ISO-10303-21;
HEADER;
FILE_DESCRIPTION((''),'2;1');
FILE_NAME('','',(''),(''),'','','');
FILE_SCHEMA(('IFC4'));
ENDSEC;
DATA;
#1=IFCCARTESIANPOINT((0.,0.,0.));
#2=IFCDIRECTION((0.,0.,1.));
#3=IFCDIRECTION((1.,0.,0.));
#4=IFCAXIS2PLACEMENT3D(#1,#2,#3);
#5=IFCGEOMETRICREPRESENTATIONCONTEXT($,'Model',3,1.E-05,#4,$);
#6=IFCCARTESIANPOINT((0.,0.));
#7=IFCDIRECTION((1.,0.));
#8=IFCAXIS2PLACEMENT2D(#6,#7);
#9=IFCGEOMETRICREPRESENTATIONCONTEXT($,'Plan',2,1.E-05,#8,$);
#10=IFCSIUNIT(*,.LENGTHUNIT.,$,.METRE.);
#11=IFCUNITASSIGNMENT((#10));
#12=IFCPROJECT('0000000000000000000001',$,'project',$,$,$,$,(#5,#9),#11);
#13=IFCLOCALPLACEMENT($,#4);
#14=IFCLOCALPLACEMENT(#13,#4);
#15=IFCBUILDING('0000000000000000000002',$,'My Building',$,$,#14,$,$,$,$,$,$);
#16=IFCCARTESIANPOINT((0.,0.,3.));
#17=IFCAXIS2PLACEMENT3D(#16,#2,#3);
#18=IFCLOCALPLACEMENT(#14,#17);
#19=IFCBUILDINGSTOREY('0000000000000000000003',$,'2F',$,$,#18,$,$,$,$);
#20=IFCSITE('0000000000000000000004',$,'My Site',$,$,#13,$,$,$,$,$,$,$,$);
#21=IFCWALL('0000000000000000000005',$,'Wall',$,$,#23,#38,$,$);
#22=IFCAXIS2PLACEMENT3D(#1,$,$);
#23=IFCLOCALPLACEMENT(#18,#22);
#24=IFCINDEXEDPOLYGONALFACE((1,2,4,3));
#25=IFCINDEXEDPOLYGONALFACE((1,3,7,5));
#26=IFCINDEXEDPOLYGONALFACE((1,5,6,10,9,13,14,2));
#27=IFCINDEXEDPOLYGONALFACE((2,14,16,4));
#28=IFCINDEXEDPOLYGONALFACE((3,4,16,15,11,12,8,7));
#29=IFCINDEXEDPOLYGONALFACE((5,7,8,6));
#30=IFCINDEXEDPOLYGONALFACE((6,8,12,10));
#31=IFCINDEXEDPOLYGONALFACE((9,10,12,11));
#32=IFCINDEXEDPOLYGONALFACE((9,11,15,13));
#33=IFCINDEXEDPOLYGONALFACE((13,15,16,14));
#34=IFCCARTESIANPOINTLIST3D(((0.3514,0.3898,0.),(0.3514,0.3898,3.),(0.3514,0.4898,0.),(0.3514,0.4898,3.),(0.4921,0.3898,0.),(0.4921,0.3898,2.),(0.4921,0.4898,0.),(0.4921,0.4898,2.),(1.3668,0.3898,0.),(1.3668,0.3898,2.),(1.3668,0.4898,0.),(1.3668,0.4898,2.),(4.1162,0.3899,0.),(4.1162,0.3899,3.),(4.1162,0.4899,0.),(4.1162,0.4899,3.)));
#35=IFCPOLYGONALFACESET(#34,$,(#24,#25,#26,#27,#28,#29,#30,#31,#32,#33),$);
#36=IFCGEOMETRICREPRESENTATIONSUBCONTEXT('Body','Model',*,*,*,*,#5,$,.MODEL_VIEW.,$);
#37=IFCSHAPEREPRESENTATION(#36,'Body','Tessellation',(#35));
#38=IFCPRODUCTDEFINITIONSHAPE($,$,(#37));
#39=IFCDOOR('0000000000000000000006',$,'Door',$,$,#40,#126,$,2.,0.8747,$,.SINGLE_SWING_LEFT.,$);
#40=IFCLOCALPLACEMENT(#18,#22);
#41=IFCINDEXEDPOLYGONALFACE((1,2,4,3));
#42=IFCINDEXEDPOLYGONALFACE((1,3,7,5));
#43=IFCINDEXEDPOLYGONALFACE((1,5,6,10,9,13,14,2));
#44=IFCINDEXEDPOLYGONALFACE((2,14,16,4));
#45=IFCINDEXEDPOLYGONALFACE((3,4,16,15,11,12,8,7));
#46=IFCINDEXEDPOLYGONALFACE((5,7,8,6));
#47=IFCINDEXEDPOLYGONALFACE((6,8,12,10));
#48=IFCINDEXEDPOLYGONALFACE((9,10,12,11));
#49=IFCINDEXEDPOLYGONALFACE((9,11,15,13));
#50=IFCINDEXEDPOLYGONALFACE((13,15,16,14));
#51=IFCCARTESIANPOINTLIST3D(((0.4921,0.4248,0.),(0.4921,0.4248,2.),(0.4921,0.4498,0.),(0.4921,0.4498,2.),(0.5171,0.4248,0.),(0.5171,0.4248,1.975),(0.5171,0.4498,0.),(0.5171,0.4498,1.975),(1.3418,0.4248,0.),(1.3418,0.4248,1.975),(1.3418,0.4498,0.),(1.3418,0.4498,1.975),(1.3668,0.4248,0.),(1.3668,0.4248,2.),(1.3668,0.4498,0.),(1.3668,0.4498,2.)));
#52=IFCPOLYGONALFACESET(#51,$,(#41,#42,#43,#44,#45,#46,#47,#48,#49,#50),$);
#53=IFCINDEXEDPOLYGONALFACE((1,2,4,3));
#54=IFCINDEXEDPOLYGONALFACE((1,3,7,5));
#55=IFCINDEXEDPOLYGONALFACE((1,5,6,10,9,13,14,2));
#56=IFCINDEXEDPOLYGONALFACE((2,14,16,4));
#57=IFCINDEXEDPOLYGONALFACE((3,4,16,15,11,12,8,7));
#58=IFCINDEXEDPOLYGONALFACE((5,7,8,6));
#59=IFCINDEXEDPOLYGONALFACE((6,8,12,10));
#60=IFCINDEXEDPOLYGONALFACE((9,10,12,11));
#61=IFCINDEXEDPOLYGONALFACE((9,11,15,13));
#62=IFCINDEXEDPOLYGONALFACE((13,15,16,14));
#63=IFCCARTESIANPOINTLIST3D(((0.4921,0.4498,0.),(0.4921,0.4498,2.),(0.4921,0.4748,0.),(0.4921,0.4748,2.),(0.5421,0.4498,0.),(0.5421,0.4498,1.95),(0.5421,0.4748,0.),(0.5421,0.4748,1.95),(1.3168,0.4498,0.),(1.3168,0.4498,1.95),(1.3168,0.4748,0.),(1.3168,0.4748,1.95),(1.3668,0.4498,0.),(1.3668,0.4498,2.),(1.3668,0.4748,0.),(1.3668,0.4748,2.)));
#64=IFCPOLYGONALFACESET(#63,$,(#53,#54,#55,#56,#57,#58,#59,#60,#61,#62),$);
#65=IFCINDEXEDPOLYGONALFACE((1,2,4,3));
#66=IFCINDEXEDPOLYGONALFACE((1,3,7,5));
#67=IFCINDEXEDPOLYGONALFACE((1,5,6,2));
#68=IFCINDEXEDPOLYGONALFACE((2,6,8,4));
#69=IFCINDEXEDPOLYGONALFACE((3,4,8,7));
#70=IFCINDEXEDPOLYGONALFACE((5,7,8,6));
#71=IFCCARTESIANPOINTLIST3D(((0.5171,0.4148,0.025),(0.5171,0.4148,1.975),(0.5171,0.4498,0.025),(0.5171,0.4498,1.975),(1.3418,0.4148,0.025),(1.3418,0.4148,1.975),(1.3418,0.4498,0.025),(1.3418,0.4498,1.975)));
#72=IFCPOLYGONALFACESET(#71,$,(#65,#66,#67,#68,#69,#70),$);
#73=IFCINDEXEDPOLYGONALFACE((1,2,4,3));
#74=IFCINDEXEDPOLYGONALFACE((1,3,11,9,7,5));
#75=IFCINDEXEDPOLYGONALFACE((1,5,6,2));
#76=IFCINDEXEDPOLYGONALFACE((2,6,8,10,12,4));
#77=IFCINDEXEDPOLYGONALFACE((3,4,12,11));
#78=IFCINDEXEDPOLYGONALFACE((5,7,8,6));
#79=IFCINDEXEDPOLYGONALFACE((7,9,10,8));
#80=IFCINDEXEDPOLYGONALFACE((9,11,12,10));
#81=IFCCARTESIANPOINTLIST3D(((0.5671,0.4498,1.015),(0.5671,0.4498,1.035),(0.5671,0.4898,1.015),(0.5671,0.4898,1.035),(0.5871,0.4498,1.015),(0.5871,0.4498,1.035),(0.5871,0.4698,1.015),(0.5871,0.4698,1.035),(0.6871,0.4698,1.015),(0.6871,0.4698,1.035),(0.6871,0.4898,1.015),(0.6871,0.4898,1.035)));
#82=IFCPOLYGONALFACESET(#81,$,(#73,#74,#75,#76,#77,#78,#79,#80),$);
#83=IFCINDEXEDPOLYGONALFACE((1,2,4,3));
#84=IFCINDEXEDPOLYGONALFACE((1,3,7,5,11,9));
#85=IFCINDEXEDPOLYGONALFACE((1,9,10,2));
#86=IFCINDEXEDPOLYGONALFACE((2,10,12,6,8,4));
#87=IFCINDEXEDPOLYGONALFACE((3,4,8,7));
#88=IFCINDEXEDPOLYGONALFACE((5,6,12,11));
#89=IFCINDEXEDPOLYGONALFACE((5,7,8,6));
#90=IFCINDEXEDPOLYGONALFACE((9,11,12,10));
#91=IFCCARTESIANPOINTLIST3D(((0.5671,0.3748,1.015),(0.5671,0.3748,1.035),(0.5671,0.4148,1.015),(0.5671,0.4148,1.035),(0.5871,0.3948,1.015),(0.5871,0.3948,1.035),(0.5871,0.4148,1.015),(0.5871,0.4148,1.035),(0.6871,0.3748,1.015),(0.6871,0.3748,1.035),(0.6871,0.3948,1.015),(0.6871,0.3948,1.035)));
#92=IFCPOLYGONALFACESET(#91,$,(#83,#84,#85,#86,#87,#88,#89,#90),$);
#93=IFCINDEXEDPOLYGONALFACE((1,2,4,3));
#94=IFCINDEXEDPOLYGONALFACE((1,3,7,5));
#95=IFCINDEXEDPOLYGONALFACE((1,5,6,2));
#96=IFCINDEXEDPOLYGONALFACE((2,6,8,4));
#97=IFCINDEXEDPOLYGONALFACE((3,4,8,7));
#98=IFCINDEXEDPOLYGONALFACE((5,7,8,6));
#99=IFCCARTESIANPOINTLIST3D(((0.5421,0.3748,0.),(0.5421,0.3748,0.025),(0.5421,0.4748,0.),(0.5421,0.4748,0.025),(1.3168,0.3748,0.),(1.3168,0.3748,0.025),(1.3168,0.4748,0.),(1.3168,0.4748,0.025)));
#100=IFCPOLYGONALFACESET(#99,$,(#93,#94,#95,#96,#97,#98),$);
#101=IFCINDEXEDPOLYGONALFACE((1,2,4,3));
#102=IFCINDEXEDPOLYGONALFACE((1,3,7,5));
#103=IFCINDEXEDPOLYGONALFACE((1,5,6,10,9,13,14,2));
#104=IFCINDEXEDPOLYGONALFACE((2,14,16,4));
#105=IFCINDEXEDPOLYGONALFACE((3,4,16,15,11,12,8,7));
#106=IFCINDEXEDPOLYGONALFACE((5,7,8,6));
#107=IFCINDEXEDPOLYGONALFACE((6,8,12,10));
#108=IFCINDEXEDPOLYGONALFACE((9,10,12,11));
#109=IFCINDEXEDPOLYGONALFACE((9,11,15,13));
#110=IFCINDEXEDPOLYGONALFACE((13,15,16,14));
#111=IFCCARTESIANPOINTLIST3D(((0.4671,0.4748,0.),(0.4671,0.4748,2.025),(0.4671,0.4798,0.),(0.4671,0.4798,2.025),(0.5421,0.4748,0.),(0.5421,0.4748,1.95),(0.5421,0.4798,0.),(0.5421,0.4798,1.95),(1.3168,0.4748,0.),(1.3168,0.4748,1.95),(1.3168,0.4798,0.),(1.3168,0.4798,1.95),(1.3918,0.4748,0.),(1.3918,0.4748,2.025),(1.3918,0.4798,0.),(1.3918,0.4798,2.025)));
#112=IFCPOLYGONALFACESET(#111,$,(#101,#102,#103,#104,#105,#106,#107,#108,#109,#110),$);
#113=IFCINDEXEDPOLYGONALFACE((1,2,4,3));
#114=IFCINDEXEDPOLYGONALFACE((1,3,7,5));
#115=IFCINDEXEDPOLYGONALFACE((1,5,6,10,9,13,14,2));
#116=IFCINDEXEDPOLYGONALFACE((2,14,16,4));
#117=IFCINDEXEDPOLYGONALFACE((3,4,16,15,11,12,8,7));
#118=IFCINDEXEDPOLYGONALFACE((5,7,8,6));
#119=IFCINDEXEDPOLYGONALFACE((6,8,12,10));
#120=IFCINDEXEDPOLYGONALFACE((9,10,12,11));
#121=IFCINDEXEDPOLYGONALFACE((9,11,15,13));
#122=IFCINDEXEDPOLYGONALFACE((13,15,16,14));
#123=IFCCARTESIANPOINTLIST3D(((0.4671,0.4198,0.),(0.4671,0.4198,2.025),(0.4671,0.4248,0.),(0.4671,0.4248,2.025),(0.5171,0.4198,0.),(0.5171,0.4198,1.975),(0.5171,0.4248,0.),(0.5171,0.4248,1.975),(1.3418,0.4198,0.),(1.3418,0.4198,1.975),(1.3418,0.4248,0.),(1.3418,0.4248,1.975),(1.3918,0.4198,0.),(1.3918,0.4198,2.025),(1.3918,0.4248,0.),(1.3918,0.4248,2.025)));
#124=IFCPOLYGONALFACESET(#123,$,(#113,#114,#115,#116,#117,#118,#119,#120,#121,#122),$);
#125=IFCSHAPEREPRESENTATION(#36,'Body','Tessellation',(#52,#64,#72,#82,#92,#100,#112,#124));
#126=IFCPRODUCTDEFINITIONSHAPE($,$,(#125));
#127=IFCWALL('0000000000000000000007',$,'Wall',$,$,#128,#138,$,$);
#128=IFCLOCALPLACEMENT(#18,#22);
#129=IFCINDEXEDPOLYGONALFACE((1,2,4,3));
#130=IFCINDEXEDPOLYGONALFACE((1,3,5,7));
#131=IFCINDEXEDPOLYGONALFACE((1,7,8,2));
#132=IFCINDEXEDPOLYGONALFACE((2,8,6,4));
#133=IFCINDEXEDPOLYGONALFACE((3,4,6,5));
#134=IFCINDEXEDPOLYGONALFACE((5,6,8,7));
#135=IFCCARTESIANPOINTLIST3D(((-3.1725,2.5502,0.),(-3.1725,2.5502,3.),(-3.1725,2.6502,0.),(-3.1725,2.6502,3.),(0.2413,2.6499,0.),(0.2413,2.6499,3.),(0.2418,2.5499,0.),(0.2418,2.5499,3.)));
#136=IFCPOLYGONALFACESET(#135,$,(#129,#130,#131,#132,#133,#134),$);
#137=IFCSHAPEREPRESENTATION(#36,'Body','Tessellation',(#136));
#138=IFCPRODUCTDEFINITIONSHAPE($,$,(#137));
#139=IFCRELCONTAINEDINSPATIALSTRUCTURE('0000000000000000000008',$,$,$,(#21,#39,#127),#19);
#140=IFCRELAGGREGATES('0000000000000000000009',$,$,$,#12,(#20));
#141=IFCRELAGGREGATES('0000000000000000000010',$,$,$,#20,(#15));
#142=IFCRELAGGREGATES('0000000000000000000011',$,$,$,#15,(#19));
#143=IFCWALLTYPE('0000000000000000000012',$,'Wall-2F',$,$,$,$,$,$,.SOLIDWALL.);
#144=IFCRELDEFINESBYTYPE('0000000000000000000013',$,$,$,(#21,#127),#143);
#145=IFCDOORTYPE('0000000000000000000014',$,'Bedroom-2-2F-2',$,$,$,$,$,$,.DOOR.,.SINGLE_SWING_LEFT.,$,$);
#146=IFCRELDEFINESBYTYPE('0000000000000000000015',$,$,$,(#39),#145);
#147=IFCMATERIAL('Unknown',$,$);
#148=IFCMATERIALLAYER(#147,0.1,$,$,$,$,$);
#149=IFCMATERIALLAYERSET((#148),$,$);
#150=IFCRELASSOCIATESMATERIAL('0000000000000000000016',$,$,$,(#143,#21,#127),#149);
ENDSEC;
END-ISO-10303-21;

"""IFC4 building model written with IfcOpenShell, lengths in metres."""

from ifc_helpers import new_model, entity, si_unit, frame, origin_with_axes, origin_2d_with_axis, place, context, subcontext, project, spatial, line, indexed_curve, outline, extrude, shape, source, transform, mapped, material, layer, layer_set, layer_usage, type_object, type_shapes, element, fill, save


model = new_model("IFC4")

# Units and contexts
model_context = context("Model", 3, precision=1e-05, world=origin_with_axes())
plan_context = context("Plan", 2, precision=1e-05, world=origin_2d_with_axis())
body_context_1 = subcontext(model_context, "Body", "Model", "MODEL_VIEW")
body_context_2 = subcontext(plan_context, "Body", "Plan", "PLAN_VIEW")
ifc_project = project(units=[si_unit("LENGTHUNIT", "METRE")], contexts=[model_context, plan_context])

# Site, building, storey
site_placement = place(None, origin_with_axes())
site = spatial("IfcSite", under=ifc_project, at=site_placement, Name="My Site")
building_placement = place(site_placement, origin_with_axes())
building = spatial("IfcBuilding", under=site, at=building_placement, Name="My Building")
storey_placement = place(building_placement, frame((0.0, 0.0, 3.0), z_axis=(0.0, 0.0, 1.0), x_axis=(1.0, 0.0, 0.0)))
storey = spatial("IfcBuildingStorey", under=building, at=storey_placement, Name="2F")

# Shared definitions
ifc_material = material(Name="Unknown")

# Shared definitions
ifc_layer_1 = layer(ifc_material, 0.1)
ifc_layer_set_1 = layer_set([ifc_layer_1])
wall_type = type_object("IfcWallType", Name="Wall-2F", PredefinedType="SOLIDWALL", material=ifc_layer_set_1)

# Wall, opening, door
ifc_layer_usage_1 = layer_usage(ifc_layer_set_1, "AXIS2", "POSITIVE", 0.0)
wall_1_placement = place(storey_placement, frame((0.3514, 0.3898, 0.0), z_axis=(0.0, 0.0, 1.0), x_axis=(1.0, 0.000024, 0.0)))
wall_1 = element("IfcWall", 1, at=wall_1_placement, inside=storey, type_object=wall_type, material=ifc_layer_usage_1, Name="Wall", context=body_context_1, shape_type="SweptSolid", body=[
    extrude(outline(indexed_curve([(0.0, 0.0), (0.0, 0.1), (3.7648, 0.1), (3.7648, 0.0)], segments=[line(1, 2, 3, 4, 1)])), origin_with_axes(), (0.0, 0.0, 1.0), 3.0),
])
shared_shape_1 = source(origin_with_axes(), body_context_1, "Body", "SweptSolid", [
    extrude(outline(indexed_curve([(0.0, 0.0), (0.8747, 0.0), (0.8747, 2.0), (0.0, 2.0)], segments=[line(1, 2, 3, 4, 1)])), frame((0.0, -0.6, 0.0), z_axis=(0.0, -1.0, 0.0), x_axis=(1.0, 0.0, 0.0)), (0.0, 0.0, -1.0), 1.2),
])
opening_1_placement = place(wall_1_placement, frame((0.1407, 0.0, 0.0), z_axis=(0.0, 0.0, 1.0), x_axis=(1.0, 0.0, 0.0)))
opening_1 = element("IfcOpeningElement", 2, at=opening_1_placement, cuts=wall_1, PredefinedType="OPENING", context=body_context_1, shape_type="MappedRepresentation", body=[
    mapped(shared_shape_1, transform((0.0, 0.0, 0.0), x_axis=(1.0, 0.0, 0.0), y_axis=(0.0, 1.0, 0.0), z_axis=(0.0, 0.0, 1.0), scale=1.0)),
])
door_type_1 = type_object("IfcDoorType", Name="Bedroom-2-2F-2", OperationType="SINGLE_SWING_LEFT", PredefinedType="DOOR")
shared_shape_2 = source(origin_with_axes(), body_context_1, "Body", "SweptSolid", [
    extrude(outline(indexed_curve([(0.0, 0.0), (0.0, 2.0), (0.8747, 2.0), (0.8747, 0.0), (0.8497, 0.0), (0.8497, 1.975), (0.025, 1.975), (0.025, 0.0)], segments=[line(1, 2, 3, 4, 5, 6, 7, 8, 1)])), frame((0.0, 0.025, 0.0), z_axis=(0.0, -1.0, 0.0), x_axis=(1.0, 0.0, 0.0)), (0.0, 0.0, -1.0), 0.025),
    extrude(outline(indexed_curve([(0.0, 0.0), (0.0, 2.0), (0.8747, 2.0), (0.8747, 0.0), (0.8247, 0.0), (0.8247, 1.95), (0.05, 1.95), (0.05, 0.0)], segments=[line(1, 2, 3, 4, 5, 6, 7, 8, 1)])), frame((0.0, 0.0, 0.0), z_axis=(0.0, -1.0, 0.0), x_axis=(1.0, 0.0, 0.0)), (0.0, 0.0, -1.0), 0.025),
    extrude(outline(indexed_curve([(0.0, 0.0), (0.8247, 0.0), (0.8247, 0.035), (0.0, 0.035)], segments=[line(1, 2, 3, 4, 1)])), frame((0.025, 0.025, 0.025), z_axis=(0.0, 0.0, 1.0), x_axis=(1.0, 0.0, 0.0)), (0.0, 0.0, 1.0), 1.95),
    extrude(outline(indexed_curve([(0.0, 0.0), (0.0, -0.04), (-0.12, -0.04), (-0.12, -0.02), (-0.02, -0.02), (-0.02, 0.0)], segments=[line(1, 2, 3, 4, 5, 6, 1)])), frame((0.7997, 0.025, 1.015), z_axis=(0.0, 0.0, 1.0), x_axis=(1.0, 0.0, 0.0)), (0.0, 0.0, 1.0), 0.02),
    extrude(outline(indexed_curve([(0.0, 0.0), (0.0, 0.04), (-0.12, 0.04), (-0.12, 0.02), (-0.02, 0.02), (-0.02, 0.0)], segments=[line(1, 2, 3, 4, 5, 6, 1)])), frame((0.7997, 0.06, 1.015), z_axis=(0.0, 0.0, 1.0), x_axis=(1.0, 0.0, 0.0)), (0.0, 0.0, 1.0), 0.02),
    extrude(outline(indexed_curve([(0.0, 0.0), (0.7747, 0.0), (0.7747, 0.1), (0.0, 0.1)], segments=[line(1, 2, 3, 4, 1)])), frame((0.05, 0.0, 0.0), z_axis=(0.0, 0.0, 1.0), x_axis=(1.0, 0.0, 0.0)), (0.0, 0.0, 1.0), 0.025),
    extrude(outline(indexed_curve([(0.0, 0.0), (0.0, 2.025), (0.9247, 2.025), (0.9247, 0.0), (0.8497, 0.0), (0.8497, 1.95), (0.075, 1.95), (0.075, 0.0)], segments=[line(1, 2, 3, 4, 5, 6, 7, 8, 1)])), frame((-0.025, -0.005, 0.0), z_axis=(0.0, -1.0, 0.0), x_axis=(1.0, 0.0, 0.0)), (0.0, 0.0, -1.0), 0.005),
    extrude(outline(indexed_curve([(0.0, 0.0), (0.0, 2.025), (0.9247, 2.025), (0.9247, 0.0), (0.8747, 0.0), (0.8747, 1.975), (0.05, 1.975), (0.05, 0.0)], segments=[line(1, 2, 3, 4, 5, 6, 7, 8, 1)])), frame((-0.025, 0.05, 0.0), z_axis=(0.0, -1.0, 0.0), x_axis=(1.0, 0.0, 0.0)), (0.0, 0.0, -1.0), 0.005),
])
shared_shape_3 = source(origin_with_axes(), body_context_2, "Body", "Curve2D", [
    entity("IfcIndexedPolyCurve", entity("IfcCartesianPointList2D", [[0.0, 0.0], [0.0, 0.05], [0.025, 0.05], [0.025, 0.025], [0.05, 0.025], [0.05, 0.0]]), [entity("IfcLineIndex", [1, 2, 3, 4, 5, 6, 1])]),
    entity("IfcIndexedPolyCurve", entity("IfcCartesianPointList2D", [[0.8747, 0.0], [0.8747, 0.05], [0.8497, 0.05], [0.8497, 0.025], [0.8247, 0.025], [0.8247, 0.0]]), [entity("IfcLineIndex", [1, 2, 3, 4, 5, 6, 1])]),
    entity("IfcTrimmedCurve", entity("IfcEllipse", entity("IfcAxis2Placement2D", entity("IfcCartesianPoint", [0.06, 0.05]), entity("IfcDirection", [1.0, 0.0])), 0.7897, 0.8247), [entity("IfcCartesianPoint", [0.8497, 0.05])], [entity("IfcCartesianPoint", [0.06, 0.8747])], True, "CARTESIAN"),
    entity("IfcIndexedPolyCurve", entity("IfcCartesianPointList2D", [[0.025, 0.05], [0.06, 0.05], [0.06, 0.8747], [0.025, 0.8747]]), [entity("IfcLineIndex", [1, 2, 3, 4, 1])]),
])
type_shapes(door_type_1, [shared_shape_2, shared_shape_3])
door_1_placement = place(opening_1_placement, frame((0.8747, 0.085, 0.0), z_axis=(0.0, 0.0, 1.0), x_axis=(-1.0, 0.0, 0.0)))
door_1 = element("IfcDoor", 3, at=door_1_placement, inside=storey, type_object=door_type_1, Name="Door", OperationType="SINGLE_SWING_LEFT", OverallHeight=2.0, OverallWidth=0.8747, shapes=[
    shape(body_context_1, "Body", "MappedRepresentation", [mapped(shared_shape_2, transform((0.0, 0.0, 0.0), x_axis=(1.0, 0.0, 0.0), y_axis=(0.0, 1.0, 0.0), z_axis=(0.0, 0.0, 1.0), scale=1.0))]),
    shape(body_context_2, "Body", "MappedRepresentation", [mapped(shared_shape_3, transform((0.0, 0.0, 0.0), x_axis=(1.0, 0.0, 0.0), y_axis=(0.0, 1.0, 0.0), z_axis=(0.0, 0.0, 1.0), scale=1.0))]),
])
fill(opening_1, door_1)

# Wall
ifc_layer_usage_2 = layer_usage(ifc_layer_set_1, "AXIS2", "POSITIVE", 0.0)
wall_2_placement = place(storey_placement, frame((-3.1725, 2.5502, 0.0), z_axis=(0.0, 0.0, 1.0), x_axis=(1.0, -0.000076, 0.0)))
element("IfcWall", 4, at=wall_2_placement, inside=storey, type_object=wall_type, material=ifc_layer_usage_2, Name="Wall", context=body_context_1, shape_type="SweptSolid", body=[
    extrude(outline(indexed_curve([(0.0, 0.0), (0.0, 0.1), (3.4138, 0.1), (3.4144, 0.0)], segments=[line(1, 2, 3, 4, 1)])), origin_with_axes(), (0.0, 0.0, 1.0), 3.0),
])

save(model, "model.ifc")
